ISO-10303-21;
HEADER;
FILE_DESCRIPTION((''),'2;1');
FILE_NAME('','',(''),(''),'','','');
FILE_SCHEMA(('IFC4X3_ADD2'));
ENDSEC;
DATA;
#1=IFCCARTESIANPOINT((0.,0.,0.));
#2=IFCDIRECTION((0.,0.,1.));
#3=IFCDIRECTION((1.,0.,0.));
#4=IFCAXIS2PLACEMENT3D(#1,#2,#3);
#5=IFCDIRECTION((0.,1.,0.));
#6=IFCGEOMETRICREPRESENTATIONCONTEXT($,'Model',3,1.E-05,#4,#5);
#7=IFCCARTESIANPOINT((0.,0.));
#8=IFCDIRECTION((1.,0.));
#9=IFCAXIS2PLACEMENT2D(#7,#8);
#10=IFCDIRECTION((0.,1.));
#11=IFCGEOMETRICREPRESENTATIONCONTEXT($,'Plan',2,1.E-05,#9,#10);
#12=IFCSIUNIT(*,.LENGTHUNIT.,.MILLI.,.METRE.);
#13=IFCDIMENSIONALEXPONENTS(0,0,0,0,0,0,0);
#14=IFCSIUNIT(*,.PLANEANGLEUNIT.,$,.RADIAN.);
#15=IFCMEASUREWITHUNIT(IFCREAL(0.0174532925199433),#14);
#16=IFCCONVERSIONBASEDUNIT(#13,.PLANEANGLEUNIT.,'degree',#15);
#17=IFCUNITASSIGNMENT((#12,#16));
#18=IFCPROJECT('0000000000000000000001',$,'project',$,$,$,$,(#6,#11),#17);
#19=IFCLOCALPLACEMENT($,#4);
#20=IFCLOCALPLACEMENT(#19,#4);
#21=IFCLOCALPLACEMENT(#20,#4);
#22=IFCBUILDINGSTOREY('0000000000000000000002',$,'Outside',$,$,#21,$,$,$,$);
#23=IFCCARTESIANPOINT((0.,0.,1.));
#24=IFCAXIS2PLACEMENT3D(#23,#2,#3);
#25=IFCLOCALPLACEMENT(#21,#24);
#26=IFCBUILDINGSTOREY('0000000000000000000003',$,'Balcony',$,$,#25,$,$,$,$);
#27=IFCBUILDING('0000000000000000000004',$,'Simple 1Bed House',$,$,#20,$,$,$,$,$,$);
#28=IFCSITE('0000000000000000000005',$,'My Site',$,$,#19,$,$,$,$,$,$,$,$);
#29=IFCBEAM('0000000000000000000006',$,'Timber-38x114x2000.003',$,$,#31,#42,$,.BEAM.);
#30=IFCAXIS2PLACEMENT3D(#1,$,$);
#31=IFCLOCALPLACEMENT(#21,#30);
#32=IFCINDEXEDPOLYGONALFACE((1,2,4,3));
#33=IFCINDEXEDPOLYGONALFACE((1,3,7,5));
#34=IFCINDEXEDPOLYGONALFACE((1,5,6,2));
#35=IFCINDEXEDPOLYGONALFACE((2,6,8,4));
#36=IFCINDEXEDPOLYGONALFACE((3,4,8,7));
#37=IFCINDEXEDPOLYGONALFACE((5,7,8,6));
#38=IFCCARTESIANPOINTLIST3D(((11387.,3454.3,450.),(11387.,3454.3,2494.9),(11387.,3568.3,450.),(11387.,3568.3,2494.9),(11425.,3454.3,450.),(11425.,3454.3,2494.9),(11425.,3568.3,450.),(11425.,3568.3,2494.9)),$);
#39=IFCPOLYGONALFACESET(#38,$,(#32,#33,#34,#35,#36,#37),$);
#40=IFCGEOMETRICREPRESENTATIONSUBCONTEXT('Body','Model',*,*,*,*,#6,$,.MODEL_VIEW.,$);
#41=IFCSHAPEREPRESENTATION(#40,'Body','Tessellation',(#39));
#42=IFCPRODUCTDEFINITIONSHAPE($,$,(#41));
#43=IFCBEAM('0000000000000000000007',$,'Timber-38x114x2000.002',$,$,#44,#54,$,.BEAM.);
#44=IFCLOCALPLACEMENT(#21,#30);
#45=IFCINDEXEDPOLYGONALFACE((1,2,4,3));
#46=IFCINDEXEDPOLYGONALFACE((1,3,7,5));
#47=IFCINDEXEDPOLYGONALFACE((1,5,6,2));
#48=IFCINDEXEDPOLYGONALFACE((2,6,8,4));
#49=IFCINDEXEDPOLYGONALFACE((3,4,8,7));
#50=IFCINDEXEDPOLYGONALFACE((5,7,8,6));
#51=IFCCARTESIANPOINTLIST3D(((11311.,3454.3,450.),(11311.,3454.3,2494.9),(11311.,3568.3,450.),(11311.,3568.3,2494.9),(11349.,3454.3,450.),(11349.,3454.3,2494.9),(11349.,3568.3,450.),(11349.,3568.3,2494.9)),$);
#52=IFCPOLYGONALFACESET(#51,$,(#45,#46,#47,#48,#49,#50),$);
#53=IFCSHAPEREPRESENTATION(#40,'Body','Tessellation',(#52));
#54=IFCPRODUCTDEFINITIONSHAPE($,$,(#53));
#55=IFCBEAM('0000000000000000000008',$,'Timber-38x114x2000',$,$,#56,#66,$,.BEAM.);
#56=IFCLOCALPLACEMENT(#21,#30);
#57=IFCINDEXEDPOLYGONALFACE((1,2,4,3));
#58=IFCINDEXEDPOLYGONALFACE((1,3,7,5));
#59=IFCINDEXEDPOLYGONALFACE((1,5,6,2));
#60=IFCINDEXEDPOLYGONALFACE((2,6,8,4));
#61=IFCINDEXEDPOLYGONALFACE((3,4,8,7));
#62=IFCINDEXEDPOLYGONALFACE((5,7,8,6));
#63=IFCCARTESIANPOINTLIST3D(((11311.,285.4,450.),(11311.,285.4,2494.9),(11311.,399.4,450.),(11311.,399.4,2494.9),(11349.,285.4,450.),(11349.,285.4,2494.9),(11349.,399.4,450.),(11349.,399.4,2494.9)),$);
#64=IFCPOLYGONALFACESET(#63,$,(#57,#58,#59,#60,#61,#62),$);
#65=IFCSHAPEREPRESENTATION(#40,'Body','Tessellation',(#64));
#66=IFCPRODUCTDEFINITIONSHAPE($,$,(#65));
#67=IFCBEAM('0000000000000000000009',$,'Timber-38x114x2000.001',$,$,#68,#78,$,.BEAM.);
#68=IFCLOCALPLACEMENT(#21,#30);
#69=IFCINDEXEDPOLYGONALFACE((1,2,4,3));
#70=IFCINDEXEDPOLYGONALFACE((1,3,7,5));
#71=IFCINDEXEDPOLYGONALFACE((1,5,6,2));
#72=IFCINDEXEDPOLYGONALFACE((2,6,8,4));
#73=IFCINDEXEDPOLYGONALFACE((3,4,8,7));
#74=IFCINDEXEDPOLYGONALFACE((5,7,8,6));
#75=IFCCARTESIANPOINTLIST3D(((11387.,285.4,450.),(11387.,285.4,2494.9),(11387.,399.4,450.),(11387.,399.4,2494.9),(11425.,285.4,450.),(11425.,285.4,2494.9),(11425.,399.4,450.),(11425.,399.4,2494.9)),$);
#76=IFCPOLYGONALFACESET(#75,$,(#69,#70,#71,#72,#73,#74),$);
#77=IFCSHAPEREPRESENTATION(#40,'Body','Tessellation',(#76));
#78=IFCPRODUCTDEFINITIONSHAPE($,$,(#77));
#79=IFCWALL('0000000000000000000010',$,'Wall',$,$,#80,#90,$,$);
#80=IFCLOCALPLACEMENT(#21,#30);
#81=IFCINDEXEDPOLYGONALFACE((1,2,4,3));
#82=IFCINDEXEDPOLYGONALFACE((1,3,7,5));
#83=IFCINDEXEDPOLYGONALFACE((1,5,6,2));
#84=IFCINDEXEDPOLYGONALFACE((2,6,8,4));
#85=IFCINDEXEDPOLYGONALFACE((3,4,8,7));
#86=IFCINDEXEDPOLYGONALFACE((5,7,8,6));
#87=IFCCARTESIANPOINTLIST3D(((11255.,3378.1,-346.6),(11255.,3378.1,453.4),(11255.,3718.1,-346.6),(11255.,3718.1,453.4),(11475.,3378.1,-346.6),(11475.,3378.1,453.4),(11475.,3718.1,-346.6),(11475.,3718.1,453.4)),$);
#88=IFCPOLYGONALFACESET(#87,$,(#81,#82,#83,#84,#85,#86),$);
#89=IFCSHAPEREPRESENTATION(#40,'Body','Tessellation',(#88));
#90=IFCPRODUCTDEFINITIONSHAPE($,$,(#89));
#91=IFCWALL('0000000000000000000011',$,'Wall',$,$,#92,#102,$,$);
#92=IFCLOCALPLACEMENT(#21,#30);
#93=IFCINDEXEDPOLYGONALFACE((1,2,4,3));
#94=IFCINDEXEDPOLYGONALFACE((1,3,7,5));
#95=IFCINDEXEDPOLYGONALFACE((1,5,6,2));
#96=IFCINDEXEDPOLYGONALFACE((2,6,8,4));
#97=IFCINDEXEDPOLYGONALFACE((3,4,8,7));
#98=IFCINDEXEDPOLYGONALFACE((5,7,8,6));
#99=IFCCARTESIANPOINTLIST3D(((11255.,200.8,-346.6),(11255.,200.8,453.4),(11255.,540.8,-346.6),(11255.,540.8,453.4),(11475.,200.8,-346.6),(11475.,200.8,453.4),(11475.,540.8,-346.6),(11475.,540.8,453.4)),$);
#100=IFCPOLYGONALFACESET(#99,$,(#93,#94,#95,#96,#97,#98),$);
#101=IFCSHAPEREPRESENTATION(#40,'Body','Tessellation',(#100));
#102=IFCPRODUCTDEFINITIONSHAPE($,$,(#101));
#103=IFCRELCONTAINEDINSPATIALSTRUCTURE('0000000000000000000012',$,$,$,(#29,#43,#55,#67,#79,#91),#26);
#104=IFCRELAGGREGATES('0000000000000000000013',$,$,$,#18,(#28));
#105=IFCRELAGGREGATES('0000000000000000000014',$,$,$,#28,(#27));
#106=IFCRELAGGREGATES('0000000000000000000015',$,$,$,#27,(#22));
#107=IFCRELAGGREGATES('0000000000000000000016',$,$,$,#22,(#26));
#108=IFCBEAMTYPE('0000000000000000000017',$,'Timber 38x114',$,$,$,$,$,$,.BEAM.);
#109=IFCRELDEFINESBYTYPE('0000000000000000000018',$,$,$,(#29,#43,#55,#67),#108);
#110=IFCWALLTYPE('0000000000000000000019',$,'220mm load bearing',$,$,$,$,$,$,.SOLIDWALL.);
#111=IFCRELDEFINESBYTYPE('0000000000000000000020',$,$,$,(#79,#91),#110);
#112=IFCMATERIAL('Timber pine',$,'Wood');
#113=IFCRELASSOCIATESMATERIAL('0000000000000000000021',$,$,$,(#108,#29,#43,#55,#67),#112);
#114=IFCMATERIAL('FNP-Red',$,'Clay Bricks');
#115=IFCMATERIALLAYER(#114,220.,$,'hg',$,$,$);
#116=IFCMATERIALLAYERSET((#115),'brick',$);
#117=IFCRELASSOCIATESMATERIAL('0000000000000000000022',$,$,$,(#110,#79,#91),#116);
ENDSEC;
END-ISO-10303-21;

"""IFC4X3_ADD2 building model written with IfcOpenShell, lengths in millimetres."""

from ifc_helpers import new_model, entity, si_unit, converted_unit, direction, frame, origin_with_axes, origin_2d_with_axis, place, context, subcontext, project, spatial, indexed_curve, rectangle, outline, extrude, material, layer, layer_set, layer_usage, material_profile, profile_set, profile_usage, type_object, element, save


model = new_model("IFC4X3_ADD2")

# Units and contexts
model_context = context("Model", 3, precision=1e-05, world=origin_with_axes(), true_north=direction((0.0, 1.0, 0.0)))
plan_context = context("Plan", 2, precision=1e-05, world=origin_2d_with_axis(), true_north=direction((0.0, 1.0)))
body_context = subcontext(model_context, "Body", "Model", "MODEL_VIEW")
ifc_project = project(units=[si_unit("LENGTHUNIT", "METRE", prefix="MILLI"), converted_unit("PLANEANGLEUNIT", "degree", entity("IfcReal", 0.0174532925199433), si_unit("PLANEANGLEUNIT", "RADIAN"), dimensions=[0, 0, 0, 0, 0, 0, 0])], contexts=[model_context, plan_context])

# Site, building, storeys
site_placement = place(None, origin_with_axes())
site = spatial("IfcSite", under=ifc_project, at=site_placement, Name="My Site")
building_placement = place(site_placement, origin_with_axes())
building = spatial("IfcBuilding", under=site, at=building_placement, Name="Simple 1Bed House")
storey_1_placement = place(building_placement, origin_with_axes())
storey_1 = spatial("IfcBuildingStorey", under=building, at=storey_1_placement, Name="Outside")
storey_2_placement = place(storey_1_placement, frame((0.0, 0.0, 1.0), z_axis=(0.0, 0.0, 1.0), x_axis=(1.0, 0.0, 0.0)))
storey_2 = spatial("IfcBuildingStorey", under=storey_1, at=storey_2_placement, Name="Balcony")

# Beams
ifc_material_1 = material(Name="Timber pine", Category="Wood")
ifc_material_profile = material_profile(ifc_material_1, rectangle(XDim=38.0, YDim=114.0))
ifc_profile_set = profile_set([ifc_material_profile], Name="timber-material")
ifc_profile_usage_1 = profile_usage(ifc_profile_set, cardinal=5)
beam_type = type_object("IfcBeamType", Name="Timber 38x114", PredefinedType="BEAM", material=ifc_profile_set)
beam_1_placement = place(storey_2_placement, frame((11406.0, 3511.3, 449.0), z_axis=(0.0, 0.0, 1.0), x_axis=(-1.0, 0.0, 0.0)))
element("IfcBeam", 1, at=beam_1_placement, inside=storey_2, type_object=beam_type, material=ifc_profile_usage_1, Name="Timber-38x114x2000.003", PredefinedType="BEAM", context=body_context, shape_type="SweptSolid", body=[
    extrude(rectangle(XDim=38.0, YDim=114.0), origin_with_axes(), (0.0, 0.0, 1.0), 2044.9),
])
ifc_profile_usage_2 = profile_usage(ifc_profile_set, cardinal=5)
beam_2_placement = place(storey_2_placement, frame((11330.0, 3511.3, 449.0), z_axis=(0.0, 0.0, 1.0), x_axis=(-1.0, 0.0, 0.0)))
element("IfcBeam", 2, at=beam_2_placement, inside=storey_2, type_object=beam_type, material=ifc_profile_usage_2, Name="Timber-38x114x2000.002", PredefinedType="BEAM", context=body_context, shape_type="SweptSolid", body=[
    extrude(rectangle(XDim=38.0, YDim=114.0), origin_with_axes(), (0.0, 0.0, 1.0), 2044.9),
])
ifc_profile_usage_3 = profile_usage(ifc_profile_set, cardinal=5)
beam_3_placement = place(storey_2_placement, frame((11330.0, 342.4, 449.0), z_axis=(0.0, 0.0, 1.0), x_axis=(-1.0, 0.0, 0.0)))
element("IfcBeam", 3, at=beam_3_placement, inside=storey_2, type_object=beam_type, material=ifc_profile_usage_3, Name="Timber-38x114x2000", PredefinedType="BEAM", context=body_context, shape_type="SweptSolid", body=[
    extrude(rectangle(XDim=38.0, YDim=114.0), origin_with_axes(), (0.0, 0.0, 1.0), 2044.9),
])
ifc_profile_usage_4 = profile_usage(ifc_profile_set, cardinal=5)
beam_4_placement = place(storey_2_placement, frame((11406.0, 342.4, 449.0), z_axis=(0.0, 0.0, 1.0), x_axis=(-1.0, 0.0, 0.0)))
element("IfcBeam", 4, at=beam_4_placement, inside=storey_2, type_object=beam_type, material=ifc_profile_usage_4, Name="Timber-38x114x2000.001", PredefinedType="BEAM", context=body_context, shape_type="SweptSolid", body=[
    extrude(rectangle(XDim=38.0, YDim=114.0), origin_with_axes(), (0.0, 0.0, 1.0), 2044.9),
])

# Walls
ifc_material_2 = material(Name="FNP-Red", Category="Clay Bricks")
ifc_layer_1 = layer(ifc_material_2, 220.0, Name="hg")
ifc_layer_set_1 = layer_set([ifc_layer_1], Name="brick")
ifc_layer_usage_1 = layer_usage(ifc_layer_set_1, "AXIS2", "POSITIVE", 0.0)
wall_type = type_object("IfcWallType", Name="220mm load bearing", PredefinedType="SOLIDWALL", material=ifc_layer_set_1)
wall_1_placement = place(storey_2_placement, frame((11475.0, 3378.1, -347.6), z_axis=(0.0, 0.0, 1.0), x_axis=(0.0, 1.0, 0.0)))
element("IfcWall", 5, at=wall_1_placement, inside=storey_2, type_object=wall_type, material=ifc_layer_usage_1, Name="Wall", context=body_context, shape_type="SweptSolid", body=[
    extrude(outline(indexed_curve([(0.0, 0.0), (0.0, 220.0), (340.0, 220.0), (340.0, 0.0), (0.0, 0.0)], self_intersect=False)), origin_with_axes(), (0.0, 0.0, 1.0), 800.0),
])
ifc_layer_usage_2 = layer_usage(ifc_layer_set_1, "AXIS2", "POSITIVE", 0.0)
wall_2_placement = place(storey_2_placement, frame((11475.0, 200.8, -347.6), z_axis=(0.0, 0.0, 1.0), x_axis=(0.0, 1.0, 0.0)))
element("IfcWall", 6, at=wall_2_placement, inside=storey_2, type_object=wall_type, material=ifc_layer_usage_2, Name="Wall", context=body_context, shape_type="SweptSolid", body=[
    extrude(outline(indexed_curve([(0.0, 0.0), (0.0, 220.0), (340.0, 220.0), (340.0, 0.0), (0.0, 0.0)], self_intersect=False)), origin_with_axes(), (0.0, 0.0, 1.0), 800.0),
])

save(model, "model.ifc")
